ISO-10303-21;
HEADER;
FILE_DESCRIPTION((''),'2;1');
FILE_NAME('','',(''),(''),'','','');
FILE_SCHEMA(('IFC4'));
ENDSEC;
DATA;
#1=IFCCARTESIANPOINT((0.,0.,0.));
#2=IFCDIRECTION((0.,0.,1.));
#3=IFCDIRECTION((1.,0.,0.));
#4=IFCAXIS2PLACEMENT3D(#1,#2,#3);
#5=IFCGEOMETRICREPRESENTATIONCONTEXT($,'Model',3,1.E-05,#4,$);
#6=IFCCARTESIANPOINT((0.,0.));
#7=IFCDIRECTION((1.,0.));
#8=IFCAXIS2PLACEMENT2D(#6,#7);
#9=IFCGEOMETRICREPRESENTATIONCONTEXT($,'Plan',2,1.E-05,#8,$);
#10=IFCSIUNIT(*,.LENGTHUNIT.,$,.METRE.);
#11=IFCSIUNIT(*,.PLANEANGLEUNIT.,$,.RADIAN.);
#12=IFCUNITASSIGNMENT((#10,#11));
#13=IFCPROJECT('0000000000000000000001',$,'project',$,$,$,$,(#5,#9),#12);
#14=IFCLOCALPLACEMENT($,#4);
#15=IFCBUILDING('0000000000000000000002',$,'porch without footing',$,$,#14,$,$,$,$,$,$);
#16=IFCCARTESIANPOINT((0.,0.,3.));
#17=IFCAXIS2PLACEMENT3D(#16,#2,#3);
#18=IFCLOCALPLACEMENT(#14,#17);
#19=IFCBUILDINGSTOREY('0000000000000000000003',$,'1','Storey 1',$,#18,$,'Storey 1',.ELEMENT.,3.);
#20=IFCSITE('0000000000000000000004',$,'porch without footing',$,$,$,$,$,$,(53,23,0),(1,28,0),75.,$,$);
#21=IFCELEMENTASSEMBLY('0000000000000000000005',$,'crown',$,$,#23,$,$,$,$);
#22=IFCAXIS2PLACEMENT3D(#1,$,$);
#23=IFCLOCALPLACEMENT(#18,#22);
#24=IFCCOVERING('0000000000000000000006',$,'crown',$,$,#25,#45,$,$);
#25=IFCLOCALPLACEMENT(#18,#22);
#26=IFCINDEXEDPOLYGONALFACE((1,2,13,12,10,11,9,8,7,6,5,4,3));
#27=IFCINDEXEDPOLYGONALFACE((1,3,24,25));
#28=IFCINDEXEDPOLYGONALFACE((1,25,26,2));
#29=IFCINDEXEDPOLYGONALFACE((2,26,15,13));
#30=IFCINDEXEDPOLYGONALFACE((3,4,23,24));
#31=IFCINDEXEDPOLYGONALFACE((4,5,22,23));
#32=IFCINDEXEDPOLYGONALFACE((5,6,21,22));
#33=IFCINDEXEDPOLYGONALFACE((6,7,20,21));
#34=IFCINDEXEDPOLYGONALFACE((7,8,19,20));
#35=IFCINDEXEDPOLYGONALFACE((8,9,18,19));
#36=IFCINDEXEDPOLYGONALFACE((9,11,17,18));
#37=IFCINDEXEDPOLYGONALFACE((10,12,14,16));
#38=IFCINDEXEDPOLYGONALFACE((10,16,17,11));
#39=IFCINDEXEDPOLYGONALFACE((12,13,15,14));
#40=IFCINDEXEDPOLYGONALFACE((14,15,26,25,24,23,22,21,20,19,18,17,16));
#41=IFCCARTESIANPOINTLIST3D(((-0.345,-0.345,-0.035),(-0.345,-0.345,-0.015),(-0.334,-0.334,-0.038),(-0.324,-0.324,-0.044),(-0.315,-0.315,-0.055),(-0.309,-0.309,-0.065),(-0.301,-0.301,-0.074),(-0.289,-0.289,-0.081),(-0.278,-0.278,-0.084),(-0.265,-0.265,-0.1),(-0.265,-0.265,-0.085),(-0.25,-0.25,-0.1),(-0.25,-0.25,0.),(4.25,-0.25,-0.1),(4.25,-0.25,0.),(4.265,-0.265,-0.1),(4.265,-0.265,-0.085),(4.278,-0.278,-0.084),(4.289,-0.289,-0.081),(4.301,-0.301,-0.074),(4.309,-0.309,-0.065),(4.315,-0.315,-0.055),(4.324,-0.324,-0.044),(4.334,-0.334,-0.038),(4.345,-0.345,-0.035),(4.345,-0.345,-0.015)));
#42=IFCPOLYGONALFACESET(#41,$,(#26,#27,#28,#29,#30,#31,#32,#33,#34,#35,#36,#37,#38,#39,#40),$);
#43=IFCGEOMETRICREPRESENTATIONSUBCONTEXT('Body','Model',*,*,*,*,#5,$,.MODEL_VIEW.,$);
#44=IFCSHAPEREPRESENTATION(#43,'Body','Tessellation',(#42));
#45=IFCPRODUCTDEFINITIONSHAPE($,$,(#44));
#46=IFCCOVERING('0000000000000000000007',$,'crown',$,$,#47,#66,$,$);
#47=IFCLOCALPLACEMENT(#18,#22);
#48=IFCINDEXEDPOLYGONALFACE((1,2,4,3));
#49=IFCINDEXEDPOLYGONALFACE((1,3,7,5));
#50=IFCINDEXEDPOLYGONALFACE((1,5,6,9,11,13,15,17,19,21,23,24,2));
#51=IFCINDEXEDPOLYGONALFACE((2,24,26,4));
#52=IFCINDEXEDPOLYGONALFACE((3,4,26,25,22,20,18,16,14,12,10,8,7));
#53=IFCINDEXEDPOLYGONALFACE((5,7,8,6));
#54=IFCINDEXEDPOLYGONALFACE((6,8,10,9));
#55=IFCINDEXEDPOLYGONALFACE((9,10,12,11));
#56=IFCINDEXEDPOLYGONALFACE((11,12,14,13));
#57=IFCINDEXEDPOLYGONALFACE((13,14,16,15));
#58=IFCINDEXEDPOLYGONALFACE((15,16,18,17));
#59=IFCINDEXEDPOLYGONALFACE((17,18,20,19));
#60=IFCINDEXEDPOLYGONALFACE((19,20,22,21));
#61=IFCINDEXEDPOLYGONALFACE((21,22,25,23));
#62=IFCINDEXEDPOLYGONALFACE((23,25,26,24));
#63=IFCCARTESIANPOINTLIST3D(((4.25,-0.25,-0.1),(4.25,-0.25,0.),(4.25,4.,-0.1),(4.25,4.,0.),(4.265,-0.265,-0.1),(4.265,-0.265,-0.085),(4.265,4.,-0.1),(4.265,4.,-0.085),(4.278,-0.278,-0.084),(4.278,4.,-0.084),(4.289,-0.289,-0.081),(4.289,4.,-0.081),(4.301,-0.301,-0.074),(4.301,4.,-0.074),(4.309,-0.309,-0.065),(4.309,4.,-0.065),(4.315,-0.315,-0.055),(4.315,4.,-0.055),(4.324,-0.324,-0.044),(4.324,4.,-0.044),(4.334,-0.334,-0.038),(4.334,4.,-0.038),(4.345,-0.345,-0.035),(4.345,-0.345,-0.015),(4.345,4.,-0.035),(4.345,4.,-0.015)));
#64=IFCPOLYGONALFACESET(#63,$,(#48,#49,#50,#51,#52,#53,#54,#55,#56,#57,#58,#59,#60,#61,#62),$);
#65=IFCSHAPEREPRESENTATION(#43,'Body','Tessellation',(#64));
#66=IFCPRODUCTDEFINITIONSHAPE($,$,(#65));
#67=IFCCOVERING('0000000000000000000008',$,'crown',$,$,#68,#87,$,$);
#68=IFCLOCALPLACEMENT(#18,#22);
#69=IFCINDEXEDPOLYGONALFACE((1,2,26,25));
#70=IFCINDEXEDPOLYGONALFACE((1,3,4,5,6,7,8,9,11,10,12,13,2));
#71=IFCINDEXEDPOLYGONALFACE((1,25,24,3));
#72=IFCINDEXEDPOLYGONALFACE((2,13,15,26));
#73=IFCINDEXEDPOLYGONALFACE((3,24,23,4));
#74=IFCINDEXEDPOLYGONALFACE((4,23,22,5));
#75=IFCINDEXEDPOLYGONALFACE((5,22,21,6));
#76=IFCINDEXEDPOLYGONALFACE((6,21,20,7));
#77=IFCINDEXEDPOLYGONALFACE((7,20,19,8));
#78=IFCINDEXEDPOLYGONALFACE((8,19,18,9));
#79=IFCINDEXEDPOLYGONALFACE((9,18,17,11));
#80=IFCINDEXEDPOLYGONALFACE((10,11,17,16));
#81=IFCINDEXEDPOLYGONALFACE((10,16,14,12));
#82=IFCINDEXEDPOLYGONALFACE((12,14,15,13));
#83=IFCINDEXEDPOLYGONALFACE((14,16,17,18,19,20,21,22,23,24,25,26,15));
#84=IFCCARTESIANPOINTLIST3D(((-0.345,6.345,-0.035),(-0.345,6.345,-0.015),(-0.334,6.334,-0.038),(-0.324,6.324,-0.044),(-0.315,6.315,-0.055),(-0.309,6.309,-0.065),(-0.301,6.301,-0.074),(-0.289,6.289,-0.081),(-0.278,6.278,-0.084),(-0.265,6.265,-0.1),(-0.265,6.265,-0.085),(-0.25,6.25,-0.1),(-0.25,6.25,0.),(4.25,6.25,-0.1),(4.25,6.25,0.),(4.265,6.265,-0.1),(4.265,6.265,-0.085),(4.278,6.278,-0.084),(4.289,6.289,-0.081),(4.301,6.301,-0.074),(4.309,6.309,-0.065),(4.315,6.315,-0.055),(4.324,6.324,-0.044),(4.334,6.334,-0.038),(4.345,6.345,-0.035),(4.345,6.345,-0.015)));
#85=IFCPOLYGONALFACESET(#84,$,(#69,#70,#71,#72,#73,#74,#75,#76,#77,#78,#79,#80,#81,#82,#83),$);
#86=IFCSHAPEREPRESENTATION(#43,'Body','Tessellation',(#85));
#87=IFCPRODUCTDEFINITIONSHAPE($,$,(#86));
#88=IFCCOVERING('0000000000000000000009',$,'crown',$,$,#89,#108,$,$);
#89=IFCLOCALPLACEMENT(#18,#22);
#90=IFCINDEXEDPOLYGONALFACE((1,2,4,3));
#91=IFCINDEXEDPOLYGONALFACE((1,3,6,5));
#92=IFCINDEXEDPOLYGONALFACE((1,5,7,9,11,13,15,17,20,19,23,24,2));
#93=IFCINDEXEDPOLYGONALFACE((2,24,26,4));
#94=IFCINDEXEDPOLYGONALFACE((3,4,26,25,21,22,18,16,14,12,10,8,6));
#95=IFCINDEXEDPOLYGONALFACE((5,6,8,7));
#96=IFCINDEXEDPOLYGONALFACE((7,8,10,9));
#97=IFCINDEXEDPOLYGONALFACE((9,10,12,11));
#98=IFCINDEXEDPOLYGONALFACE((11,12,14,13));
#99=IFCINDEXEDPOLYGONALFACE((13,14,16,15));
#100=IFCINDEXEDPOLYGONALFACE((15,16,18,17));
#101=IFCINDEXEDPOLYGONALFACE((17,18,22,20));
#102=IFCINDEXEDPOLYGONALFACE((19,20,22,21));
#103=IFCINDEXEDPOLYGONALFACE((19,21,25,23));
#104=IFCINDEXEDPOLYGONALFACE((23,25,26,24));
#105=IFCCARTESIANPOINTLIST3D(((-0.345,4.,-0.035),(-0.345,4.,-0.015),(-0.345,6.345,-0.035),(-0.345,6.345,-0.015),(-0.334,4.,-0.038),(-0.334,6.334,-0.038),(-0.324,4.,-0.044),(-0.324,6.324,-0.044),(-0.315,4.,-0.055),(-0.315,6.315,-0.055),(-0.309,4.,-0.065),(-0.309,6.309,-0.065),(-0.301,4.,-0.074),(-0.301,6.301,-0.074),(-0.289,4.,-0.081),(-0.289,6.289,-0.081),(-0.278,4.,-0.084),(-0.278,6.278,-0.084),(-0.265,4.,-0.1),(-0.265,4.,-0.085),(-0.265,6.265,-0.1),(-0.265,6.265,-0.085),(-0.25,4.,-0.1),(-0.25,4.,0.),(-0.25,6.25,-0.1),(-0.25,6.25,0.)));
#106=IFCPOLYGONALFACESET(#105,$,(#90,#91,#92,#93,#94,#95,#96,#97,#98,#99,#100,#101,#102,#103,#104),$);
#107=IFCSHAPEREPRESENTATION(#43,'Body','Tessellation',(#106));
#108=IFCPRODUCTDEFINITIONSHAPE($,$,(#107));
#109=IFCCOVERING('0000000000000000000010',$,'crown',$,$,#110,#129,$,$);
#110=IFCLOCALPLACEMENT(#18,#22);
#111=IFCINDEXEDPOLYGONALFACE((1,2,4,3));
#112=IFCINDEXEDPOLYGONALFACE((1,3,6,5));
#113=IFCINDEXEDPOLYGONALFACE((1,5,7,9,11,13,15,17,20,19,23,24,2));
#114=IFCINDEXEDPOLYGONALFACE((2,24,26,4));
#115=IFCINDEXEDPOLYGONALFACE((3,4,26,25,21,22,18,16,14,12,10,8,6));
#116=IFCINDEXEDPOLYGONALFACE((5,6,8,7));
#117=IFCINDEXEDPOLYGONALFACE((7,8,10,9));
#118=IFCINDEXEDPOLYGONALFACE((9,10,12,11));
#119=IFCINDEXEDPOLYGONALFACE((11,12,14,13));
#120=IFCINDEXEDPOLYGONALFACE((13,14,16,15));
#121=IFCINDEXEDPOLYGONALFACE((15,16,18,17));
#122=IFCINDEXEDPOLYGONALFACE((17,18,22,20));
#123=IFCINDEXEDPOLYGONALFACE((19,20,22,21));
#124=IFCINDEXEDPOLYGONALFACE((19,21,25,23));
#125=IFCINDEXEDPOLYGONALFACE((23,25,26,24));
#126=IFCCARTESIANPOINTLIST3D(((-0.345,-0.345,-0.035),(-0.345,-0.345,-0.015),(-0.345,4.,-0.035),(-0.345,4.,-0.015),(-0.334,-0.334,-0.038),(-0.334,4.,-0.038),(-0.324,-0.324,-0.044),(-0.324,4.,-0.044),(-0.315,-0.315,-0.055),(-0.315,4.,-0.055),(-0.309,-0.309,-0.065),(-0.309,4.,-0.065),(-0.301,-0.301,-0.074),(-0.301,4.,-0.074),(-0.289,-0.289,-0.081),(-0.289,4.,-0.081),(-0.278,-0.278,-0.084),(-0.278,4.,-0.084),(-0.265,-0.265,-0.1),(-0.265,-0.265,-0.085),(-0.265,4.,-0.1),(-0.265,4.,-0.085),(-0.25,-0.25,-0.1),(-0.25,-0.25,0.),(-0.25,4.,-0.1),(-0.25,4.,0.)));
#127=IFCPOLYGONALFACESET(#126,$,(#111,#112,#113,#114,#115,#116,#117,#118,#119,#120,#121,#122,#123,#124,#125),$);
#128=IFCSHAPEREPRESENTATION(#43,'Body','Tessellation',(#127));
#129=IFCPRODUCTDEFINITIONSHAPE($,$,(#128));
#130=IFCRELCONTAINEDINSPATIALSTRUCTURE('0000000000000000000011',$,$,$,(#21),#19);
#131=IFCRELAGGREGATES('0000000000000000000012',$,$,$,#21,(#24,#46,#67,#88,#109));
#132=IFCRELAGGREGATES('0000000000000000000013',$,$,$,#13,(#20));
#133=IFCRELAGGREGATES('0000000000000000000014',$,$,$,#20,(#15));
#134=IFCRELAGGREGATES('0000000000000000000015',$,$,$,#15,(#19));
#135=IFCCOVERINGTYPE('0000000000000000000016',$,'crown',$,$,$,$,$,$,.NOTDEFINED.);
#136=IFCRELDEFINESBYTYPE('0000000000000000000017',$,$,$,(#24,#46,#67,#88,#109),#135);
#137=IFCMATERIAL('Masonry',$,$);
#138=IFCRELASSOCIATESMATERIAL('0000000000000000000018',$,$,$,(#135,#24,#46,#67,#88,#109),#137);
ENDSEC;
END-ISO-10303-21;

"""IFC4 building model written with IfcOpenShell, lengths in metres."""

from ifc_helpers import new_model, si_unit, frame, origin_with_axes, origin_2d_with_axis, place, context, subcontext, project, spatial, polyline, outline, extrude, clip, halfspace, material, material_profile, profile_set, profile_usage, type_object, element, aggregate, save


model = new_model("IFC4")

# Units and contexts
model_context = context("Model", 3, precision=1e-05, world=origin_with_axes())
plan_context = context("Plan", 2, precision=1e-05, world=origin_2d_with_axis())
body_context = subcontext(model_context, "Body", "Model", "MODEL_VIEW")
ifc_project = project(units=[si_unit("LENGTHUNIT", "METRE"), si_unit("PLANEANGLEUNIT", "RADIAN")], contexts=[model_context, plan_context])

# Site, building, storey
site = spatial("IfcSite", under=ifc_project, Name="porch without footing", RefLatitude=(53, 23, 0), RefLongitude=(1, 28, 0), RefElevation=75.0)
building_placement = place(None, origin_with_axes())
building = spatial("IfcBuilding", under=site, at=building_placement, Name="porch without footing")
storey_placement = place(building_placement, frame((0.0, 0.0, 3.0), z_axis=(0.0, 0.0, 1.0), x_axis=(1.0, 0.0, 0.0)))
storey = spatial("IfcBuildingStorey", under=building, at=storey_placement, Name="1", Description="Storey 1", LongName="Storey 1", CompositionType="ELEMENT", Elevation=3.0)

# Shared definitions
ifc_material_1 = material(Name="Masonry")

# Element assembly, coverings
assembly_1_placement = place(storey_placement, frame((0.0, 0.0, -3.0), z_axis=(0.0, 0.0, 1.0), x_axis=(1.0, 0.0, 0.0)))
assembly_1 = element("IfcElementAssembly", 1, at=assembly_1_placement, inside=storey, Name="crown")
ifc_material_profile_1 = material_profile(ifc_material_1, outline(polyline([(0.25, -0.1), (0.265, -0.1), (0.265, -0.085), (0.278, -0.084), (0.289, -0.081), (0.301, -0.074), (0.309, -0.065), (0.315, -0.055), (0.324, -0.044), (0.334, -0.038), (0.345, -0.035), (0.345, -0.015), (0.25, 0.0), (0.25, -0.1)])))
ifc_profile_set_1 = profile_set([ifc_material_profile_1])
ifc_profile_usage_1 = profile_usage(ifc_profile_set_1)
covering_type_1 = type_object("IfcCoveringType", Name="crown", PredefinedType="NOTDEFINED", material=ifc_profile_set_1)
covering_1_placement = place(assembly_1_placement, frame((5.0, 0.0, 3.0), z_axis=(-1.0, 0.0, 0.0), x_axis=(0.0, -1.0, 0.0)))
covering_1 = element("IfcCovering", 2, at=covering_1_placement, type_object=covering_type_1, material=ifc_profile_usage_1, Name="crown", context=body_context, shape_type="Clipping", body=[
    clip(clip(extrude(outline(polyline([(0.25, -0.1), (0.265, -0.1), (0.265, -0.085), (0.278, -0.084), (0.289, -0.081), (0.301, -0.074), (0.309, -0.065), (0.315, -0.055), (0.324, -0.044), (0.334, -0.038), (0.345, -0.035), (0.345, -0.015), (0.25, 0.0), (0.25, -0.1)])), origin_with_axes(), (0.0, 0.0, 1.0), 6.0), halfspace(frame((0.0, -3.0, 1.0), z_axis=(-0.707107, 0.0, -0.707107), x_axis=(0.0, 1.0, 0.0)), False)), halfspace(frame((0.0, -3.0, 5.0), z_axis=(-0.707107, 0.0, 0.707107), x_axis=(0.0, 1.0, 0.0)), False)),
])
ifc_profile_usage_2 = profile_usage(ifc_profile_set_1)
covering_2_placement = place(assembly_1_placement, frame((4.0, 5.0, 3.0), z_axis=(0.0, -1.0, 0.0), x_axis=(1.0, 0.0, 0.0)))
covering_2 = element("IfcCovering", 3, at=covering_2_placement, type_object=covering_type_1, material=ifc_profile_usage_2, Name="crown", context=body_context, shape_type="Clipping", body=[
    clip(clip(extrude(outline(polyline([(0.25, -0.1), (0.265, -0.1), (0.265, -0.085), (0.278, -0.084), (0.289, -0.081), (0.301, -0.074), (0.309, -0.065), (0.315, -0.055), (0.324, -0.044), (0.334, -0.038), (0.345, -0.035), (0.345, -0.015), (0.25, 0.0), (0.25, -0.1)])), origin_with_axes(), (0.0, 0.0, 1.0), 6.0), halfspace(frame((0.0, -3.0, 1.0), z_axis=(0.0, 0.0, -1.0), x_axis=(1.0, 0.0, 0.0)), False)), halfspace(frame((0.0, -3.0, 5.0), z_axis=(-0.707107, 0.0, 0.707107), x_axis=(0.0, 1.0, 0.0)), False)),
])
ifc_profile_usage_3 = profile_usage(ifc_profile_set_1)
covering_3_placement = place(assembly_1_placement, frame((-1.0, 6.0, 3.0), z_axis=(1.0, 0.0, 0.0), x_axis=(0.0, 1.0, 0.0)))
covering_3 = element("IfcCovering", 4, at=covering_3_placement, type_object=covering_type_1, material=ifc_profile_usage_3, Name="crown", context=body_context, shape_type="Clipping", body=[
    clip(clip(extrude(outline(polyline([(0.25, -0.1), (0.265, -0.1), (0.265, -0.085), (0.278, -0.084), (0.289, -0.081), (0.301, -0.074), (0.309, -0.065), (0.315, -0.055), (0.324, -0.044), (0.334, -0.038), (0.345, -0.035), (0.345, -0.015), (0.25, 0.0), (0.25, -0.1)])), origin_with_axes(), (0.0, 0.0, 1.0), 6.0), halfspace(frame((0.0, -3.0, 1.0), z_axis=(-0.707107, 0.0, -0.707107), x_axis=(0.0, 1.0, 0.0)), False)), halfspace(frame((0.0, -3.0, 5.0), z_axis=(-0.707107, 0.0, 0.707107), x_axis=(0.0, 1.0, 0.0)), False)),
])
ifc_profile_usage_4 = profile_usage(ifc_profile_set_1)
covering_4_placement = place(assembly_1_placement, frame((0.0, 3.0, 3.0), z_axis=(0.0, 1.0, 0.0), x_axis=(-1.0, 0.0, 0.0)))
covering_4 = element("IfcCovering", 5, at=covering_4_placement, type_object=covering_type_1, material=ifc_profile_usage_4, Name="crown", context=body_context, shape_type="Clipping", body=[
    clip(clip(extrude(outline(polyline([(0.25, -0.1), (0.265, -0.1), (0.265, -0.085), (0.278, -0.084), (0.289, -0.081), (0.301, -0.074), (0.309, -0.065), (0.315, -0.055), (0.324, -0.044), (0.334, -0.038), (0.345, -0.035), (0.345, -0.015), (0.25, 0.0), (0.25, -0.1)])), origin_with_axes(), (0.0, 0.0, 1.0), 4.0), halfspace(frame((0.0, -3.0, 1.0), z_axis=(0.0, 0.0, -1.0), x_axis=(1.0, 0.0, 0.0)), False)), halfspace(frame((0.0, -3.0, 3.0), z_axis=(-0.707107, 0.0, 0.707107), x_axis=(0.0, 1.0, 0.0)), False)),
])
ifc_profile_usage_5 = profile_usage(ifc_profile_set_1)
covering_5_placement = place(assembly_1_placement, frame((0.0, -1.0, 3.0), z_axis=(0.0, 1.0, 0.0), x_axis=(-1.0, 0.0, 0.0)))
covering_5 = element("IfcCovering", 6, at=covering_5_placement, type_object=covering_type_1, material=ifc_profile_usage_5, Name="crown", context=body_context, shape_type="Clipping", body=[
    clip(clip(extrude(outline(polyline([(0.25, -0.1), (0.265, -0.1), (0.265, -0.085), (0.278, -0.084), (0.289, -0.081), (0.301, -0.074), (0.309, -0.065), (0.315, -0.055), (0.324, -0.044), (0.334, -0.038), (0.345, -0.035), (0.345, -0.015), (0.25, 0.0), (0.25, -0.1)])), origin_with_axes(), (0.0, 0.0, 1.0), 6.0), halfspace(frame((0.0, -3.0, 1.0), z_axis=(-0.707107, 0.0, -0.707107), x_axis=(0.0, 1.0, 0.0)), False)), halfspace(frame((0.0, -3.0, 5.0), z_axis=(0.0, 0.0, 1.0), x_axis=(-1.0, 0.0, 0.0)), False)),
])
aggregate(assembly_1, [covering_1, covering_2, covering_3, covering_4, covering_5])

save(model, "model.ifc")
